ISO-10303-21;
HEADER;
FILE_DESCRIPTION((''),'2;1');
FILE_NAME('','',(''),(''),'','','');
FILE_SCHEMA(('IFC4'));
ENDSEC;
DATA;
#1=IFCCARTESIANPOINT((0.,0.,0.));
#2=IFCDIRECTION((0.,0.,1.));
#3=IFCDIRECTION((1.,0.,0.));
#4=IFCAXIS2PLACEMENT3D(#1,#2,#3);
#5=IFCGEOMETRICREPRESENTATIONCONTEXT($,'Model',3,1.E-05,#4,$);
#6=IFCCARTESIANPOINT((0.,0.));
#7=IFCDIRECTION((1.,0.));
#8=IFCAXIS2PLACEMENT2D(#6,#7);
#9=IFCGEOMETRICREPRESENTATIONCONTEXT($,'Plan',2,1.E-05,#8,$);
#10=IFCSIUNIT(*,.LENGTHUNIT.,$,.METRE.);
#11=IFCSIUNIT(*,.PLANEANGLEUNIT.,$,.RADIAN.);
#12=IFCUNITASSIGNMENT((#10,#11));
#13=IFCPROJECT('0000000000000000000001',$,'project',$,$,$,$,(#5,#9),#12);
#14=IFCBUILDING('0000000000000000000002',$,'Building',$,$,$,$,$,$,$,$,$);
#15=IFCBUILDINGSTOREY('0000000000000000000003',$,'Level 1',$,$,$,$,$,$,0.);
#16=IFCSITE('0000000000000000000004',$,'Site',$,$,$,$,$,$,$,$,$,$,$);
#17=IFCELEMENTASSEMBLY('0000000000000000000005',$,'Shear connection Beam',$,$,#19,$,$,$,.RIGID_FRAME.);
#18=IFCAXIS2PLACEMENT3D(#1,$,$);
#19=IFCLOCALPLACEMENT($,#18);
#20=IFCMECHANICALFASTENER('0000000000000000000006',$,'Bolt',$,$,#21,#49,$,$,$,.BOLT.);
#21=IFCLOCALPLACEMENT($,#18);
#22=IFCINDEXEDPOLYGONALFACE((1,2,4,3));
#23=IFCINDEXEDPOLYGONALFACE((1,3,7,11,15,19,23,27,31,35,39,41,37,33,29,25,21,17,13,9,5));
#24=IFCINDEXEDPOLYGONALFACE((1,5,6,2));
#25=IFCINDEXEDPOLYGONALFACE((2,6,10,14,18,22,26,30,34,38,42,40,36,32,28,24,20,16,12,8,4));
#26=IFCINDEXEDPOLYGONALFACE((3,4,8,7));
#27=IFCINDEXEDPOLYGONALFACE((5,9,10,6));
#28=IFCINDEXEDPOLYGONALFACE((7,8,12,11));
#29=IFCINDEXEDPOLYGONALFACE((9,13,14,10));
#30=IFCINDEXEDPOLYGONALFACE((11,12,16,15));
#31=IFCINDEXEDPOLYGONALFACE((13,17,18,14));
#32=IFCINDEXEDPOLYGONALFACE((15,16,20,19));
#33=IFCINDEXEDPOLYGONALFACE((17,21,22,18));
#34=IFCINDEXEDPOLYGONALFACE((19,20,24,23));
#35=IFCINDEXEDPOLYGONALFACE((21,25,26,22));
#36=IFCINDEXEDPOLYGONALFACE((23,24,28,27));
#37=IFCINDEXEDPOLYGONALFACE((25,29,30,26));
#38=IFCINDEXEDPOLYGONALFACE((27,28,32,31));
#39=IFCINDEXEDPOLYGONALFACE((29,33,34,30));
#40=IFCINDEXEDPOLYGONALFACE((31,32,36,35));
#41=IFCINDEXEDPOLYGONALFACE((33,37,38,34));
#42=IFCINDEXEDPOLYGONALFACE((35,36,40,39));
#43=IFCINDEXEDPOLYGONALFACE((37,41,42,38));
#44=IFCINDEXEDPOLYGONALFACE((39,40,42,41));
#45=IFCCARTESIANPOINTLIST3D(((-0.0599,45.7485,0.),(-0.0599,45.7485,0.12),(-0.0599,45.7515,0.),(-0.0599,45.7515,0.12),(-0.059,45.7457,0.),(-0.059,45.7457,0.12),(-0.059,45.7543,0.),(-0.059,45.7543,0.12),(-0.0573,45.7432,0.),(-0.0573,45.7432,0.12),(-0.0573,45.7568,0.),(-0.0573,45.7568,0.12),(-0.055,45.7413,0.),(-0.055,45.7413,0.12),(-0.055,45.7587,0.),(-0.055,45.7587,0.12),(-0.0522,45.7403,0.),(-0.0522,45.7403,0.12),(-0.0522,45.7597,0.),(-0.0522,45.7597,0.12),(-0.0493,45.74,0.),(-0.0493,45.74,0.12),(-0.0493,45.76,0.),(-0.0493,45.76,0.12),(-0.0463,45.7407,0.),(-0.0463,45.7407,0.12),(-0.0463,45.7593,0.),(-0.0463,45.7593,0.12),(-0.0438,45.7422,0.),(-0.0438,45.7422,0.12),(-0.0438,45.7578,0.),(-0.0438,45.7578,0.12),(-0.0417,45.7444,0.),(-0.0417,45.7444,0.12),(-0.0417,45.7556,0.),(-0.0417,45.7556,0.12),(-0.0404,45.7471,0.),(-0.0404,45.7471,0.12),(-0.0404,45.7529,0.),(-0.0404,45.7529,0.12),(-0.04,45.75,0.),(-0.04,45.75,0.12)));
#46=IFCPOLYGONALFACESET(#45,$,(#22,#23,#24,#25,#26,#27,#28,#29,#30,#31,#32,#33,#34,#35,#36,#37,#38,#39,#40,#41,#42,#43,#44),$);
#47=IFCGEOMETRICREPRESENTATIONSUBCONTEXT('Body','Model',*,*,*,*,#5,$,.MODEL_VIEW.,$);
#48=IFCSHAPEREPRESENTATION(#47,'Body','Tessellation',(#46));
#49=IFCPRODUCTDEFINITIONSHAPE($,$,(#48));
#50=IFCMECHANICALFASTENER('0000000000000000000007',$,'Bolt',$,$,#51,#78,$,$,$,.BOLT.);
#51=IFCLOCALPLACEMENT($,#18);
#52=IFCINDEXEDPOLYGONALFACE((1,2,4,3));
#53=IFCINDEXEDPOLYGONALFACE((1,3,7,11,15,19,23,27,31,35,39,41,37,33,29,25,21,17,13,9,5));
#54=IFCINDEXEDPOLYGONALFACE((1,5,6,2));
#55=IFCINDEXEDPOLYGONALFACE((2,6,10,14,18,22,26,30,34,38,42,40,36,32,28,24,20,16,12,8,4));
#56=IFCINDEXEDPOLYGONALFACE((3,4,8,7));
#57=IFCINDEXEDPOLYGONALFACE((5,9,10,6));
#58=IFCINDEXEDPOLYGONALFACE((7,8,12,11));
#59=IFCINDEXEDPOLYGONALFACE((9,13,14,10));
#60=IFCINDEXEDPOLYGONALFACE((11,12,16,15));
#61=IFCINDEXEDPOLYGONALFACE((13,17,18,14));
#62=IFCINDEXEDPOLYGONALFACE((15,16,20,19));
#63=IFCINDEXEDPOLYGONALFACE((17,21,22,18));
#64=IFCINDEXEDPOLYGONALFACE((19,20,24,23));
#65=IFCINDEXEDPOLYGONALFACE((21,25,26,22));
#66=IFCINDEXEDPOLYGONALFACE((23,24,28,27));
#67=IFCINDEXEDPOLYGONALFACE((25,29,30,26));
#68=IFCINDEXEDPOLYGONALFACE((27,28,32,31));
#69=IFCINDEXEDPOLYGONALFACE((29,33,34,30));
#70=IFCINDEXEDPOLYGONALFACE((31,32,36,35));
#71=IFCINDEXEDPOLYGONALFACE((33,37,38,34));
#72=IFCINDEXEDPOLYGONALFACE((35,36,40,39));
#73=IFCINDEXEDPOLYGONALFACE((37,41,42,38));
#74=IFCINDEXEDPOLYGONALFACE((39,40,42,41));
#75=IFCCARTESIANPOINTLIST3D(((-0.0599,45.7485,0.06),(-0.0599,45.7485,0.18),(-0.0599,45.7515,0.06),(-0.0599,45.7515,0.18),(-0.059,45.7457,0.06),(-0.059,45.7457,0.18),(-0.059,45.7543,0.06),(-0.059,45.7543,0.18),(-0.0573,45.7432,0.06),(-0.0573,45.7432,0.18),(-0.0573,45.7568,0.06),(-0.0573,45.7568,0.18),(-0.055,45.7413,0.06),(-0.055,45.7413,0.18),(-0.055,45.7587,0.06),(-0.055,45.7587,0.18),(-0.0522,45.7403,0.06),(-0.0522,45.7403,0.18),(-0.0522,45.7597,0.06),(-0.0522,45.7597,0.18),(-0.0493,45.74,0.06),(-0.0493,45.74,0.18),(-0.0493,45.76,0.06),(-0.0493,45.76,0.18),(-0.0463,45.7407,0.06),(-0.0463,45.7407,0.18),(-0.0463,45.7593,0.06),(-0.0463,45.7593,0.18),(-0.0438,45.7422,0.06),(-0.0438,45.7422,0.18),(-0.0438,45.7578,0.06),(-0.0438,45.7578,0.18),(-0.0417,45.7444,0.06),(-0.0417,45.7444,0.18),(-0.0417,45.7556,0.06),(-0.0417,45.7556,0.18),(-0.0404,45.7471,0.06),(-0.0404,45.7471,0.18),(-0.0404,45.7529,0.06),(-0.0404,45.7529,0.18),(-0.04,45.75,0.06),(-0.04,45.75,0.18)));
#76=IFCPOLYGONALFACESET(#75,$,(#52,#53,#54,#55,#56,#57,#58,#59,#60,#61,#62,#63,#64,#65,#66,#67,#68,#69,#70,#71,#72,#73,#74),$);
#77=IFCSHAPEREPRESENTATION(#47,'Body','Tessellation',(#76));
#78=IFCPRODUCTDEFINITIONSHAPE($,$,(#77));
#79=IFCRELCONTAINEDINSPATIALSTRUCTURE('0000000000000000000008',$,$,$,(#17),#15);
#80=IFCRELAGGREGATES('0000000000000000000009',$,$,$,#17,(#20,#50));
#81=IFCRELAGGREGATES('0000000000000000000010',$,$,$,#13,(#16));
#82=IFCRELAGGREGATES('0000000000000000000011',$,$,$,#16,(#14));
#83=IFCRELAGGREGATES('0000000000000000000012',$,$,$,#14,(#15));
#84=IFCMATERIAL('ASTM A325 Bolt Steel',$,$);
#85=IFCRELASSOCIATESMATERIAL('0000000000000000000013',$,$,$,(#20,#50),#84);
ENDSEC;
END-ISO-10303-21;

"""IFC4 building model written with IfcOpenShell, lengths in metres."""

from ifc_helpers import new_model, si_unit, frame, origin_with_axes, origin_2d, origin_2d_with_axis, place, context, subcontext, project, spatial, circle, extrude, material, element, aggregate, save


model = new_model("IFC4")

# Units and contexts
model_context = context("Model", 3, precision=1e-05, world=origin_with_axes())
plan_context = context("Plan", 2, precision=1e-05, world=origin_2d_with_axis())
body_context = subcontext(model_context, "Body", "Model", "MODEL_VIEW")
ifc_project = project(units=[si_unit("LENGTHUNIT", "METRE"), si_unit("PLANEANGLEUNIT", "RADIAN")], contexts=[model_context, plan_context])

# Site, building, storey
site = spatial("IfcSite", under=ifc_project, Name="Site")
building = spatial("IfcBuilding", under=site, Name="Building")
storey = spatial("IfcBuildingStorey", under=building, Name="Level 1", Elevation=0.0)

# Element assembly
assembly_1 = element("IfcElementAssembly", 1, inside=storey, Name="Shear connection Beam", PredefinedType="RIGID_FRAME")

# Shared definitions
ifc_material_1 = material(Name="ASTM A325 Bolt Steel")

# Mechanical fasteners
mechanical_fastener_1_placement = place(None, frame((-0.05, 45.75, 0.0), z_axis=(0.0, 0.0, 1.0), x_axis=(1.0, 0.0, 0.0)))
mechanical_fastener_1 = element("IfcMechanicalFastener", 2, at=mechanical_fastener_1_placement, material=ifc_material_1, Name="Bolt", PredefinedType="BOLT", context=body_context, shape_type="SweptSolid", body=[
    extrude(circle(Radius=0.01, at=origin_2d()), origin_with_axes(), (0.0, 0.0, 1.0), 0.12),
])
mechanical_fastener_2_placement = place(None, frame((-0.05, 45.75, 0.06), z_axis=(0.0, 0.0, 1.0), x_axis=(1.0, 0.0, 0.0)))
mechanical_fastener_2 = element("IfcMechanicalFastener", 3, at=mechanical_fastener_2_placement, material=ifc_material_1, Name="Bolt", PredefinedType="BOLT", context=body_context, shape_type="SweptSolid", body=[
    extrude(circle(Radius=0.01, at=origin_2d()), origin_with_axes(), (0.0, 0.0, 1.0), 0.12),
])
aggregate(assembly_1, [mechanical_fastener_1, mechanical_fastener_2])

save(model, "model.ifc")
